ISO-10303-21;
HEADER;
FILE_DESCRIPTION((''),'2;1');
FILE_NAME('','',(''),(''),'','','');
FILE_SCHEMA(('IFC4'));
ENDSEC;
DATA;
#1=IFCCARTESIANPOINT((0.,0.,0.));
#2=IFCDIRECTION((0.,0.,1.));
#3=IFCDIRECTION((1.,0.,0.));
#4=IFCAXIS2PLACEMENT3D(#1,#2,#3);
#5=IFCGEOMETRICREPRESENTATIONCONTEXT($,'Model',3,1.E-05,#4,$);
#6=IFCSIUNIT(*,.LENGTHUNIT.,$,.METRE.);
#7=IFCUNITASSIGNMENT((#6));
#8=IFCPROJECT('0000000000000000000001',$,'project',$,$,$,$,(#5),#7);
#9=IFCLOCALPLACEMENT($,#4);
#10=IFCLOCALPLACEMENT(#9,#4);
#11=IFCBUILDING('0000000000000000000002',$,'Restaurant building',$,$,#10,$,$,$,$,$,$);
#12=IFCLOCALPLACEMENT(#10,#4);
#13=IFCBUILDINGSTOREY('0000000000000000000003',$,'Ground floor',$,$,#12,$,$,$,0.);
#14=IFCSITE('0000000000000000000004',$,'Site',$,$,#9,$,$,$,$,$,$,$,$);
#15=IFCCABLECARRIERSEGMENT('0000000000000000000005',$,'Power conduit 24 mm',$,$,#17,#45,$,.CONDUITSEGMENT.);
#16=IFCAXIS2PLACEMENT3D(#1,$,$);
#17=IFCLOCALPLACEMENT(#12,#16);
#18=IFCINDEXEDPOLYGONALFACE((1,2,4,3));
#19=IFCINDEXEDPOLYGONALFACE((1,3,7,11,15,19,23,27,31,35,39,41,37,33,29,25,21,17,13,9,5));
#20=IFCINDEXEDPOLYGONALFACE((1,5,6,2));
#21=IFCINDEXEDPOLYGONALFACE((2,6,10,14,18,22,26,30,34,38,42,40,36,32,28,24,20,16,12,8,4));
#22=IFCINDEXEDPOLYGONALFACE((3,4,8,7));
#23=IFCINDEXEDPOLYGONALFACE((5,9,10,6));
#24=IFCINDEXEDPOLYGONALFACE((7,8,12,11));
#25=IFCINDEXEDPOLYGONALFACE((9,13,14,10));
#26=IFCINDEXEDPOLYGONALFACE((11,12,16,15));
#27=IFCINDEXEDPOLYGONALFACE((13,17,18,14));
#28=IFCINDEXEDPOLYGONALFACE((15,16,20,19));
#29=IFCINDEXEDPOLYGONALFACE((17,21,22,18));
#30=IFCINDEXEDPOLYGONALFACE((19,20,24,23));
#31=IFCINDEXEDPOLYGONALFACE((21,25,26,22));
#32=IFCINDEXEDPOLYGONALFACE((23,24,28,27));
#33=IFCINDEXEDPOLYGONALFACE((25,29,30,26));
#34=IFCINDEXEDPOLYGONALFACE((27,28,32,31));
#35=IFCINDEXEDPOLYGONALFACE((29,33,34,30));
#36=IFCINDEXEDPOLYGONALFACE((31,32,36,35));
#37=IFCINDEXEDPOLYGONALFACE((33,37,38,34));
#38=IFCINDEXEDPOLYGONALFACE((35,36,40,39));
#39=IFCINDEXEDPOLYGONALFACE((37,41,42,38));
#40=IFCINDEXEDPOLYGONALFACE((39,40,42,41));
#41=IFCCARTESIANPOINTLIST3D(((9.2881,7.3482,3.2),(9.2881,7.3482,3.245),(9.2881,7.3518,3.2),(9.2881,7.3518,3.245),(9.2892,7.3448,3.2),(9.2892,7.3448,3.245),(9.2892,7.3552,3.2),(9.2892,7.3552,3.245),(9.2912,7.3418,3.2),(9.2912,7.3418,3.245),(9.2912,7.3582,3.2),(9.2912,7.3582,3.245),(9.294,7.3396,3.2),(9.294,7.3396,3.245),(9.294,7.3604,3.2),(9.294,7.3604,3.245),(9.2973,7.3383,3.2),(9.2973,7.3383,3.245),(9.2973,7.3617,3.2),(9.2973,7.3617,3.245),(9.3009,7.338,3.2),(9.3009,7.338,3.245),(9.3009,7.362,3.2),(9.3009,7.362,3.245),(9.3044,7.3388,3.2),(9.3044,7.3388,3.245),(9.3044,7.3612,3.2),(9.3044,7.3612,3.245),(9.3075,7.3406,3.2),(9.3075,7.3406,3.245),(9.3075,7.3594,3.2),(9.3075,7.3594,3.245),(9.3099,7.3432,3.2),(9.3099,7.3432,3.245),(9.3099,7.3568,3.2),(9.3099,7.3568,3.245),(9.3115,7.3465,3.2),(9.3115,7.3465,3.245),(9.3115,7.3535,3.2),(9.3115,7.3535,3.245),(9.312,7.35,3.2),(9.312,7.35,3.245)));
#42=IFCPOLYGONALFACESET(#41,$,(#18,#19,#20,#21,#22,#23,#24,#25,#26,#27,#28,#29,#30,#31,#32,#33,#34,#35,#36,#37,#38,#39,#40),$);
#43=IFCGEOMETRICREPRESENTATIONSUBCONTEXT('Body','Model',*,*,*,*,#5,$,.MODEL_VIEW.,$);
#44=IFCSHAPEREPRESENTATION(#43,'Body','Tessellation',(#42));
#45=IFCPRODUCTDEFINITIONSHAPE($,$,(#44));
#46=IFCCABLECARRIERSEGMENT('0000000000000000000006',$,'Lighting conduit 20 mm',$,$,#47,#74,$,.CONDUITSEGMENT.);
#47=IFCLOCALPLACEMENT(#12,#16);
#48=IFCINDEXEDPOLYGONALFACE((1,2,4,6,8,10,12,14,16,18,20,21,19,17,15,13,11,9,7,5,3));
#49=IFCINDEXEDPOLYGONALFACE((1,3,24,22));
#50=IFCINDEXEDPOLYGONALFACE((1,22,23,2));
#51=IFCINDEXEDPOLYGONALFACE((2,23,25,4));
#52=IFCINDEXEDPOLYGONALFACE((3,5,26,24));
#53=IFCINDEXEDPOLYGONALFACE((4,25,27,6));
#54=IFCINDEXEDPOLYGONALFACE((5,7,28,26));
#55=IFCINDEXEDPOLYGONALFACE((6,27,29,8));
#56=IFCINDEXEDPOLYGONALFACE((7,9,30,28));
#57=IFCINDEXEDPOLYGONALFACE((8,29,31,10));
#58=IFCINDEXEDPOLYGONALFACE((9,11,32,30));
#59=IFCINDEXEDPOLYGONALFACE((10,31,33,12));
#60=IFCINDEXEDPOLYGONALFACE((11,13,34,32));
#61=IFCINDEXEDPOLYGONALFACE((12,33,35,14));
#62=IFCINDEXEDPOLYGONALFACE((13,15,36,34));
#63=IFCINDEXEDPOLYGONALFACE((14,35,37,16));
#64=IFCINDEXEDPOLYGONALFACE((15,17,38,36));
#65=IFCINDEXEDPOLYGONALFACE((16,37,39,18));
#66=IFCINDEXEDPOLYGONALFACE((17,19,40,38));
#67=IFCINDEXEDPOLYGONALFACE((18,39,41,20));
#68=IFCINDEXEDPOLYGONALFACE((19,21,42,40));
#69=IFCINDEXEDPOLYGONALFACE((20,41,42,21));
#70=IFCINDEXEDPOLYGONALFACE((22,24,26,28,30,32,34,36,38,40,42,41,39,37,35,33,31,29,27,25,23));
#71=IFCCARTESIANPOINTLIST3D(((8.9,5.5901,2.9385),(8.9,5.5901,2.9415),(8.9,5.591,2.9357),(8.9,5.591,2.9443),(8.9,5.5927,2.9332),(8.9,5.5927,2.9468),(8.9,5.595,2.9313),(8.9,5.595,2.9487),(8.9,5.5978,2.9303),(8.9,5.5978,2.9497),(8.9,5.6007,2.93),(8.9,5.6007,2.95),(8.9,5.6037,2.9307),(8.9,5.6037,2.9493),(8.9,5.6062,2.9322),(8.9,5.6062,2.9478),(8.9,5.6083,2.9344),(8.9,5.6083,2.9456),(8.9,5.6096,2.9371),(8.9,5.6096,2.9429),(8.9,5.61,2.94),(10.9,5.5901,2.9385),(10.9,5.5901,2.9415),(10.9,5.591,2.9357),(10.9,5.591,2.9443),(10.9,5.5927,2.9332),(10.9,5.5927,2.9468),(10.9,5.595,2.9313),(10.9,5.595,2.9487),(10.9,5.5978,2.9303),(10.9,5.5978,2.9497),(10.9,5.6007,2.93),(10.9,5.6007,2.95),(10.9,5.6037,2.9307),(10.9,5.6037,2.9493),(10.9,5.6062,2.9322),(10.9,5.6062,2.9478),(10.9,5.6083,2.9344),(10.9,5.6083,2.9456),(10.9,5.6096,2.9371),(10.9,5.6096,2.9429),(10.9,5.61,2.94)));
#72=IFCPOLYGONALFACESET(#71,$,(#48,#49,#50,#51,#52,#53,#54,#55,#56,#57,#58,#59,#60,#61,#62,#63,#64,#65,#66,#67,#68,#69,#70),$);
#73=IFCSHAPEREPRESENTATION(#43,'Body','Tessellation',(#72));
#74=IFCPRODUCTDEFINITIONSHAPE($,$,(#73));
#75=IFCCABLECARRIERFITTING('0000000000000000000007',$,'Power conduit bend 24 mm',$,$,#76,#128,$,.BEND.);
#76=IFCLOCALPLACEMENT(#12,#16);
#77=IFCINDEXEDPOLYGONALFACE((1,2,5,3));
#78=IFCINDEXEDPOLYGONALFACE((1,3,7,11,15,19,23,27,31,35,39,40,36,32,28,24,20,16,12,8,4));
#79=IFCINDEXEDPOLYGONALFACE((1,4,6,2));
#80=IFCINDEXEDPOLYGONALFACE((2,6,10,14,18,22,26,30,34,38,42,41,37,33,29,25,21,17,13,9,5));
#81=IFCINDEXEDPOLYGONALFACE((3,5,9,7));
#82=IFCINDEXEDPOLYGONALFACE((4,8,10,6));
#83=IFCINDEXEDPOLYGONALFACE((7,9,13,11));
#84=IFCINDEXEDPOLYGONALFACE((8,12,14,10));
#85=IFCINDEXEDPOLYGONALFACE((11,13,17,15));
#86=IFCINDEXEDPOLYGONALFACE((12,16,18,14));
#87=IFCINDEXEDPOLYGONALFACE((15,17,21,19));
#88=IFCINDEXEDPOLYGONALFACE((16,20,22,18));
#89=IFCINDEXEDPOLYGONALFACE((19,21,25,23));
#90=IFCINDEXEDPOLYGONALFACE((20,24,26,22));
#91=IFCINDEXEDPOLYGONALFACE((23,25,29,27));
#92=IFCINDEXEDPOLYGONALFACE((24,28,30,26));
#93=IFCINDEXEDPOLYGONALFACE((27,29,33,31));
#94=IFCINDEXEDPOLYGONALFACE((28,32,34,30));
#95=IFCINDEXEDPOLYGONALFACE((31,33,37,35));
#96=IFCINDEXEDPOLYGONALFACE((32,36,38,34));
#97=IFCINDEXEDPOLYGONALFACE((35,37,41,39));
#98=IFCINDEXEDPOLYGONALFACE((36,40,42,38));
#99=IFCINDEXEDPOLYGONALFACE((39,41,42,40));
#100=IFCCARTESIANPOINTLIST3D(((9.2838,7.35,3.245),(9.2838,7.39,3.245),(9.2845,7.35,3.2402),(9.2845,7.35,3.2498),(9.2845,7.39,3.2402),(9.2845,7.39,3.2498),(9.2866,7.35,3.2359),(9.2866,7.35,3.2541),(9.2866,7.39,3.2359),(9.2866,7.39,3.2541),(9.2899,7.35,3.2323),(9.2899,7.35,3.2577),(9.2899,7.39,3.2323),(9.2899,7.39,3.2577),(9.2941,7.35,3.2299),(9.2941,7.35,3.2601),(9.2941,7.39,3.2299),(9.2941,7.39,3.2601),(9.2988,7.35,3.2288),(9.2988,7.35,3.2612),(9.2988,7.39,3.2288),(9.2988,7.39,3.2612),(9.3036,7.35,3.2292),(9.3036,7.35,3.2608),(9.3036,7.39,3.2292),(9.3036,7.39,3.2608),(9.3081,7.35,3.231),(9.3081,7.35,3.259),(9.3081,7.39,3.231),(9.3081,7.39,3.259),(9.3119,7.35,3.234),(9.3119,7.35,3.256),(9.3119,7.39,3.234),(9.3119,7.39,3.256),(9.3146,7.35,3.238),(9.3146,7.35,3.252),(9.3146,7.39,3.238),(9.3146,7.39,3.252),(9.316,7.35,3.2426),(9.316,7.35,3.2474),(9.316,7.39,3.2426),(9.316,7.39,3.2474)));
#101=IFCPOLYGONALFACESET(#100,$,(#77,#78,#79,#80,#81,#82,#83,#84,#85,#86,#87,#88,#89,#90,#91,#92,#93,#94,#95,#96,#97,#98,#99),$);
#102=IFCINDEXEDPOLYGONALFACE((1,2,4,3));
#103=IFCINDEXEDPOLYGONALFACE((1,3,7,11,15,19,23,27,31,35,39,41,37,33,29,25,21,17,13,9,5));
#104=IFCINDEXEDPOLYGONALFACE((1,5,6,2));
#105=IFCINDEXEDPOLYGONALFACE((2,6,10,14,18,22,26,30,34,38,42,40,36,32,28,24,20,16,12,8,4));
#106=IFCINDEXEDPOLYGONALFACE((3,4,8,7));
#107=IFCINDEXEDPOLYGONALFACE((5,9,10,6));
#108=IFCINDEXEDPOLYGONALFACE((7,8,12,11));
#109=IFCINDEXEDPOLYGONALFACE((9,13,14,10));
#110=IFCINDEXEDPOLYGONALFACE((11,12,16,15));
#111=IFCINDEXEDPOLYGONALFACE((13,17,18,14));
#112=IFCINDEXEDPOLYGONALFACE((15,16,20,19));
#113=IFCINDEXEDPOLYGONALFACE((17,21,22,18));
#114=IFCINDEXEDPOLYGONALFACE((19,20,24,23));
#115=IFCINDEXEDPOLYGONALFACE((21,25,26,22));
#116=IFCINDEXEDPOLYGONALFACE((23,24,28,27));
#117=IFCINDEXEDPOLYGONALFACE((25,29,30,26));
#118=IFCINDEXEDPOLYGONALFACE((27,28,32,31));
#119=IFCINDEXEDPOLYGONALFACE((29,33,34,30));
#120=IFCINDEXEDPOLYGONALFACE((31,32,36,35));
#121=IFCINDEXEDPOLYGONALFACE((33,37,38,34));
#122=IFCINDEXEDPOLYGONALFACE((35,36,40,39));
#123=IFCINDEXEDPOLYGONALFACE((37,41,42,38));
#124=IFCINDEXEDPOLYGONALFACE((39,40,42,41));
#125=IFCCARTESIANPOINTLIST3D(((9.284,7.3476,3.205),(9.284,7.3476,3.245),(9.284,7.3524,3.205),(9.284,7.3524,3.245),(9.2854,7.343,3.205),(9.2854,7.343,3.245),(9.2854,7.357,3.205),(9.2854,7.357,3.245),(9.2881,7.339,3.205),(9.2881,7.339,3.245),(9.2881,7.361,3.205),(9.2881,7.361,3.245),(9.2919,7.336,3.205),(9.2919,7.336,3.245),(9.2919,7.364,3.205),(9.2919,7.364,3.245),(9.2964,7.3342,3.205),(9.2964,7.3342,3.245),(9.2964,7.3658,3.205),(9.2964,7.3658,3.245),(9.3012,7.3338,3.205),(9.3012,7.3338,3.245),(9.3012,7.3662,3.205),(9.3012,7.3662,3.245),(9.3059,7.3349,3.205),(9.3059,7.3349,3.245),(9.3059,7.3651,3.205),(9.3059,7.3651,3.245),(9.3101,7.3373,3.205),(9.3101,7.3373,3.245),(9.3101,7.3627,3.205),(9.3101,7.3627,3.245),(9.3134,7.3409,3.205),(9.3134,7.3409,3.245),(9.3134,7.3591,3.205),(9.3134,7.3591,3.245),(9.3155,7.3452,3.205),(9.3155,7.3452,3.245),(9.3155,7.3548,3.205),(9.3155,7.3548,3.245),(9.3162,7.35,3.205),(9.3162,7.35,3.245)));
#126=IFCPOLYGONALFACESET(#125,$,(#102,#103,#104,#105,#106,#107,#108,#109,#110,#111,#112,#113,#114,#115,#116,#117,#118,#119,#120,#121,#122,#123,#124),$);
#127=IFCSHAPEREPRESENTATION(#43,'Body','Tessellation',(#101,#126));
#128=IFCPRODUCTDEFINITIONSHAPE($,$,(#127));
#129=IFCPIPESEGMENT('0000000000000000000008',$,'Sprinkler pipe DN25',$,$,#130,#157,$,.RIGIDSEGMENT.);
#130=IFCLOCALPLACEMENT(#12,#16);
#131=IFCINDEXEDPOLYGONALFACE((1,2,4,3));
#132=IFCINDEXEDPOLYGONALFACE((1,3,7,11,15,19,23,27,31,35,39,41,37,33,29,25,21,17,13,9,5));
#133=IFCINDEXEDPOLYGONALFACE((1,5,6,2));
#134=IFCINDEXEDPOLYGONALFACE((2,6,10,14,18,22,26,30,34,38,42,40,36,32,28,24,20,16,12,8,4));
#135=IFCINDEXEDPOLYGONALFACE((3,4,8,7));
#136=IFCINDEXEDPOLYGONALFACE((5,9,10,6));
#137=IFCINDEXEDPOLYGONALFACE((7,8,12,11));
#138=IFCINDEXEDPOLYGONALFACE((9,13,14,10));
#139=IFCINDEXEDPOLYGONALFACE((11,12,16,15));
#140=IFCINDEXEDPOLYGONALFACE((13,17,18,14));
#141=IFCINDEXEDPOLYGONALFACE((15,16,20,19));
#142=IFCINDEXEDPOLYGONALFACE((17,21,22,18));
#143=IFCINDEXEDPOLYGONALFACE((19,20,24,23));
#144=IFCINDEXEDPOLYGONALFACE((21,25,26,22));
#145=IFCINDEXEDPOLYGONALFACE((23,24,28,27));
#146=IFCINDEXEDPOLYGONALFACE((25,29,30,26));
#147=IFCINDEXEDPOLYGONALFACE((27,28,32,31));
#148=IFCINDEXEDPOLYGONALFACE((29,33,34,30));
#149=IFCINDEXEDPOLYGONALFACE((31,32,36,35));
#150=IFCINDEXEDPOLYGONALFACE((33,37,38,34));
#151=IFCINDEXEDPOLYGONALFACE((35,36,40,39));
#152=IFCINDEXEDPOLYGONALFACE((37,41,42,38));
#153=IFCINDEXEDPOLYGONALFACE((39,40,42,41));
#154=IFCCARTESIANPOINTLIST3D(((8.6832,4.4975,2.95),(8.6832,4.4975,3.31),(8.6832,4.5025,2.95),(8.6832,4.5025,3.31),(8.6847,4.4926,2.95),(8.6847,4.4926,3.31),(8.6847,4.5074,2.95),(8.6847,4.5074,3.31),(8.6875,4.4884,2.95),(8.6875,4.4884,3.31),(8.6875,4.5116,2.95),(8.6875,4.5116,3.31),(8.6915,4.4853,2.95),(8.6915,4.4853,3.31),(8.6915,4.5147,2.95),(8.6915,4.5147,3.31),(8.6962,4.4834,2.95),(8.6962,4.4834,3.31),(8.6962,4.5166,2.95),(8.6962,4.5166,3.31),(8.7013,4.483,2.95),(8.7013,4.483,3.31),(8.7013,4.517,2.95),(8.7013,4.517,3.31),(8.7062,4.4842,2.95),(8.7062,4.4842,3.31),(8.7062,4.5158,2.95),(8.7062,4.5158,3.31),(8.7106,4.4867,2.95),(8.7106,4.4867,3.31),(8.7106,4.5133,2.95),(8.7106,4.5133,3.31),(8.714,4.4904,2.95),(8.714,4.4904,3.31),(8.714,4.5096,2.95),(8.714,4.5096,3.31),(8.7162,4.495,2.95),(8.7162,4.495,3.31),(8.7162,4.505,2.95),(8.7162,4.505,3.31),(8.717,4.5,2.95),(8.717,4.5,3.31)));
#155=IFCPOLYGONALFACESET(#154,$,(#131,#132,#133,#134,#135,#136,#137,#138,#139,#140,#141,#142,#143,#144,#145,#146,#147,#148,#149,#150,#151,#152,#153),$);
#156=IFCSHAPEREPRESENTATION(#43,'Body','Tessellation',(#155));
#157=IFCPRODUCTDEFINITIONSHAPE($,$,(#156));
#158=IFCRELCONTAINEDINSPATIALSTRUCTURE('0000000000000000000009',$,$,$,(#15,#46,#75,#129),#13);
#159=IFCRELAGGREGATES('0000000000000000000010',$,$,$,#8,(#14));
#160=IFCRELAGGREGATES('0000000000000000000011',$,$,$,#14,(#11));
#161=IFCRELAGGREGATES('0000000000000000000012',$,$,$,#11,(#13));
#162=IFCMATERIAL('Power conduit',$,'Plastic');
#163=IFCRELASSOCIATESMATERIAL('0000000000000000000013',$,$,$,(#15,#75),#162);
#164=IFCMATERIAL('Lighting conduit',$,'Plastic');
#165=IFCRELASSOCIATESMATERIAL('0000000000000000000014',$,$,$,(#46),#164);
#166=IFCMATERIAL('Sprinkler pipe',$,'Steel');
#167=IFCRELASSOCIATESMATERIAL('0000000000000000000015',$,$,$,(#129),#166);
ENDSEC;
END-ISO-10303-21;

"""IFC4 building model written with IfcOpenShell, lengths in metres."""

from ifc_helpers import new_model, si_unit, frame, origin_with_axes, origin_2d, place, context, subcontext, project, spatial, circle, extrude, material, element, save


model = new_model("IFC4")

# Units and contexts
model_context = context("Model", 3, precision=1e-05, world=origin_with_axes())
body_context = subcontext(model_context, "Body", "Model", "MODEL_VIEW")
ifc_project = project(units=[si_unit("LENGTHUNIT", "METRE")], contexts=[model_context])

# Site, building, storey
site_placement = place(None, origin_with_axes())
site = spatial("IfcSite", under=ifc_project, at=site_placement, Name="Site")
building_placement = place(site_placement, origin_with_axes())
building = spatial("IfcBuilding", under=site, at=building_placement, Name="Restaurant building")
storey_placement = place(building_placement, origin_with_axes())
storey = spatial("IfcBuildingStorey", under=building, at=storey_placement, Name="Ground floor", Elevation=0.0)

# Cable carrier segments
ifc_material_1 = material(Name="Power conduit", Category="Plastic")
cable_carrier_segment_1_placement = place(storey_placement, frame((9.3, 7.35, 3.245)))
element("IfcCableCarrierSegment", 1, at=cable_carrier_segment_1_placement, inside=storey, material=ifc_material_1, Name="Power conduit 24 mm", PredefinedType="CONDUITSEGMENT", context=body_context, shape_type="SweptSolid", body=[
    extrude(circle(Radius=0.012, at=origin_2d()), frame((0.0, 0.0, 0.0), z_axis=(0.0, 0.0, -1.0), x_axis=(1.0, 0.0, 0.0)), (0.0, 0.0, 1.0), 0.045),
])
ifc_material_2 = material(Name="Lighting conduit", Category="Plastic")
cable_carrier_segment_2_placement = place(storey_placement, frame((8.9, 5.6, 2.94)))
element("IfcCableCarrierSegment", 2, at=cable_carrier_segment_2_placement, inside=storey, material=ifc_material_2, Name="Lighting conduit 20 mm", PredefinedType="CONDUITSEGMENT", context=body_context, shape_type="SweptSolid", body=[
    extrude(circle(Radius=0.01, at=origin_2d()), frame((0.0, 0.0, 0.0), z_axis=(1.0, 0.0, 0.0), x_axis=(0.0, 1.0, 0.0)), (0.0, 0.0, 1.0), 2.0),
])

# Cable carrier fitting
cable_carrier_fitting_placement = place(storey_placement, frame((9.3, 7.35, 3.245)))
element("IfcCableCarrierFitting", 3, at=cable_carrier_fitting_placement, inside=storey, material=ifc_material_1, Name="Power conduit bend 24 mm", PredefinedType="BEND", context=body_context, shape_type="SweptSolid", body=[
    extrude(circle(Radius=0.0162, at=origin_2d()), frame((0.0, 0.0, 0.0), z_axis=(0.0, 1.0, 0.0), x_axis=(-1.0, 0.0, 0.0)), (0.0, 0.0, 1.0), 0.04),
    extrude(circle(Radius=0.0162, at=origin_2d()), frame((0.0, 0.0, 0.0), z_axis=(0.0, 0.0, -1.0), x_axis=(1.0, 0.0, 0.0)), (0.0, 0.0, 1.0), 0.04),
])

# Pipe segment
ifc_material_3 = material(Name="Sprinkler pipe", Category="Steel")
pipe_segment_1_placement = place(storey_placement, frame((8.7, 4.5, 3.31)))
element("IfcPipeSegment", 4, at=pipe_segment_1_placement, inside=storey, material=ifc_material_3, Name="Sprinkler pipe DN25", PredefinedType="RIGIDSEGMENT", context=body_context, shape_type="SweptSolid", body=[
    extrude(circle(Radius=0.017, at=origin_2d()), frame((0.0, 0.0, 0.0), z_axis=(0.0, 0.0, -1.0), x_axis=(1.0, 0.0, 0.0)), (0.0, 0.0, 1.0), 0.36),
])

save(model, "model.ifc")
